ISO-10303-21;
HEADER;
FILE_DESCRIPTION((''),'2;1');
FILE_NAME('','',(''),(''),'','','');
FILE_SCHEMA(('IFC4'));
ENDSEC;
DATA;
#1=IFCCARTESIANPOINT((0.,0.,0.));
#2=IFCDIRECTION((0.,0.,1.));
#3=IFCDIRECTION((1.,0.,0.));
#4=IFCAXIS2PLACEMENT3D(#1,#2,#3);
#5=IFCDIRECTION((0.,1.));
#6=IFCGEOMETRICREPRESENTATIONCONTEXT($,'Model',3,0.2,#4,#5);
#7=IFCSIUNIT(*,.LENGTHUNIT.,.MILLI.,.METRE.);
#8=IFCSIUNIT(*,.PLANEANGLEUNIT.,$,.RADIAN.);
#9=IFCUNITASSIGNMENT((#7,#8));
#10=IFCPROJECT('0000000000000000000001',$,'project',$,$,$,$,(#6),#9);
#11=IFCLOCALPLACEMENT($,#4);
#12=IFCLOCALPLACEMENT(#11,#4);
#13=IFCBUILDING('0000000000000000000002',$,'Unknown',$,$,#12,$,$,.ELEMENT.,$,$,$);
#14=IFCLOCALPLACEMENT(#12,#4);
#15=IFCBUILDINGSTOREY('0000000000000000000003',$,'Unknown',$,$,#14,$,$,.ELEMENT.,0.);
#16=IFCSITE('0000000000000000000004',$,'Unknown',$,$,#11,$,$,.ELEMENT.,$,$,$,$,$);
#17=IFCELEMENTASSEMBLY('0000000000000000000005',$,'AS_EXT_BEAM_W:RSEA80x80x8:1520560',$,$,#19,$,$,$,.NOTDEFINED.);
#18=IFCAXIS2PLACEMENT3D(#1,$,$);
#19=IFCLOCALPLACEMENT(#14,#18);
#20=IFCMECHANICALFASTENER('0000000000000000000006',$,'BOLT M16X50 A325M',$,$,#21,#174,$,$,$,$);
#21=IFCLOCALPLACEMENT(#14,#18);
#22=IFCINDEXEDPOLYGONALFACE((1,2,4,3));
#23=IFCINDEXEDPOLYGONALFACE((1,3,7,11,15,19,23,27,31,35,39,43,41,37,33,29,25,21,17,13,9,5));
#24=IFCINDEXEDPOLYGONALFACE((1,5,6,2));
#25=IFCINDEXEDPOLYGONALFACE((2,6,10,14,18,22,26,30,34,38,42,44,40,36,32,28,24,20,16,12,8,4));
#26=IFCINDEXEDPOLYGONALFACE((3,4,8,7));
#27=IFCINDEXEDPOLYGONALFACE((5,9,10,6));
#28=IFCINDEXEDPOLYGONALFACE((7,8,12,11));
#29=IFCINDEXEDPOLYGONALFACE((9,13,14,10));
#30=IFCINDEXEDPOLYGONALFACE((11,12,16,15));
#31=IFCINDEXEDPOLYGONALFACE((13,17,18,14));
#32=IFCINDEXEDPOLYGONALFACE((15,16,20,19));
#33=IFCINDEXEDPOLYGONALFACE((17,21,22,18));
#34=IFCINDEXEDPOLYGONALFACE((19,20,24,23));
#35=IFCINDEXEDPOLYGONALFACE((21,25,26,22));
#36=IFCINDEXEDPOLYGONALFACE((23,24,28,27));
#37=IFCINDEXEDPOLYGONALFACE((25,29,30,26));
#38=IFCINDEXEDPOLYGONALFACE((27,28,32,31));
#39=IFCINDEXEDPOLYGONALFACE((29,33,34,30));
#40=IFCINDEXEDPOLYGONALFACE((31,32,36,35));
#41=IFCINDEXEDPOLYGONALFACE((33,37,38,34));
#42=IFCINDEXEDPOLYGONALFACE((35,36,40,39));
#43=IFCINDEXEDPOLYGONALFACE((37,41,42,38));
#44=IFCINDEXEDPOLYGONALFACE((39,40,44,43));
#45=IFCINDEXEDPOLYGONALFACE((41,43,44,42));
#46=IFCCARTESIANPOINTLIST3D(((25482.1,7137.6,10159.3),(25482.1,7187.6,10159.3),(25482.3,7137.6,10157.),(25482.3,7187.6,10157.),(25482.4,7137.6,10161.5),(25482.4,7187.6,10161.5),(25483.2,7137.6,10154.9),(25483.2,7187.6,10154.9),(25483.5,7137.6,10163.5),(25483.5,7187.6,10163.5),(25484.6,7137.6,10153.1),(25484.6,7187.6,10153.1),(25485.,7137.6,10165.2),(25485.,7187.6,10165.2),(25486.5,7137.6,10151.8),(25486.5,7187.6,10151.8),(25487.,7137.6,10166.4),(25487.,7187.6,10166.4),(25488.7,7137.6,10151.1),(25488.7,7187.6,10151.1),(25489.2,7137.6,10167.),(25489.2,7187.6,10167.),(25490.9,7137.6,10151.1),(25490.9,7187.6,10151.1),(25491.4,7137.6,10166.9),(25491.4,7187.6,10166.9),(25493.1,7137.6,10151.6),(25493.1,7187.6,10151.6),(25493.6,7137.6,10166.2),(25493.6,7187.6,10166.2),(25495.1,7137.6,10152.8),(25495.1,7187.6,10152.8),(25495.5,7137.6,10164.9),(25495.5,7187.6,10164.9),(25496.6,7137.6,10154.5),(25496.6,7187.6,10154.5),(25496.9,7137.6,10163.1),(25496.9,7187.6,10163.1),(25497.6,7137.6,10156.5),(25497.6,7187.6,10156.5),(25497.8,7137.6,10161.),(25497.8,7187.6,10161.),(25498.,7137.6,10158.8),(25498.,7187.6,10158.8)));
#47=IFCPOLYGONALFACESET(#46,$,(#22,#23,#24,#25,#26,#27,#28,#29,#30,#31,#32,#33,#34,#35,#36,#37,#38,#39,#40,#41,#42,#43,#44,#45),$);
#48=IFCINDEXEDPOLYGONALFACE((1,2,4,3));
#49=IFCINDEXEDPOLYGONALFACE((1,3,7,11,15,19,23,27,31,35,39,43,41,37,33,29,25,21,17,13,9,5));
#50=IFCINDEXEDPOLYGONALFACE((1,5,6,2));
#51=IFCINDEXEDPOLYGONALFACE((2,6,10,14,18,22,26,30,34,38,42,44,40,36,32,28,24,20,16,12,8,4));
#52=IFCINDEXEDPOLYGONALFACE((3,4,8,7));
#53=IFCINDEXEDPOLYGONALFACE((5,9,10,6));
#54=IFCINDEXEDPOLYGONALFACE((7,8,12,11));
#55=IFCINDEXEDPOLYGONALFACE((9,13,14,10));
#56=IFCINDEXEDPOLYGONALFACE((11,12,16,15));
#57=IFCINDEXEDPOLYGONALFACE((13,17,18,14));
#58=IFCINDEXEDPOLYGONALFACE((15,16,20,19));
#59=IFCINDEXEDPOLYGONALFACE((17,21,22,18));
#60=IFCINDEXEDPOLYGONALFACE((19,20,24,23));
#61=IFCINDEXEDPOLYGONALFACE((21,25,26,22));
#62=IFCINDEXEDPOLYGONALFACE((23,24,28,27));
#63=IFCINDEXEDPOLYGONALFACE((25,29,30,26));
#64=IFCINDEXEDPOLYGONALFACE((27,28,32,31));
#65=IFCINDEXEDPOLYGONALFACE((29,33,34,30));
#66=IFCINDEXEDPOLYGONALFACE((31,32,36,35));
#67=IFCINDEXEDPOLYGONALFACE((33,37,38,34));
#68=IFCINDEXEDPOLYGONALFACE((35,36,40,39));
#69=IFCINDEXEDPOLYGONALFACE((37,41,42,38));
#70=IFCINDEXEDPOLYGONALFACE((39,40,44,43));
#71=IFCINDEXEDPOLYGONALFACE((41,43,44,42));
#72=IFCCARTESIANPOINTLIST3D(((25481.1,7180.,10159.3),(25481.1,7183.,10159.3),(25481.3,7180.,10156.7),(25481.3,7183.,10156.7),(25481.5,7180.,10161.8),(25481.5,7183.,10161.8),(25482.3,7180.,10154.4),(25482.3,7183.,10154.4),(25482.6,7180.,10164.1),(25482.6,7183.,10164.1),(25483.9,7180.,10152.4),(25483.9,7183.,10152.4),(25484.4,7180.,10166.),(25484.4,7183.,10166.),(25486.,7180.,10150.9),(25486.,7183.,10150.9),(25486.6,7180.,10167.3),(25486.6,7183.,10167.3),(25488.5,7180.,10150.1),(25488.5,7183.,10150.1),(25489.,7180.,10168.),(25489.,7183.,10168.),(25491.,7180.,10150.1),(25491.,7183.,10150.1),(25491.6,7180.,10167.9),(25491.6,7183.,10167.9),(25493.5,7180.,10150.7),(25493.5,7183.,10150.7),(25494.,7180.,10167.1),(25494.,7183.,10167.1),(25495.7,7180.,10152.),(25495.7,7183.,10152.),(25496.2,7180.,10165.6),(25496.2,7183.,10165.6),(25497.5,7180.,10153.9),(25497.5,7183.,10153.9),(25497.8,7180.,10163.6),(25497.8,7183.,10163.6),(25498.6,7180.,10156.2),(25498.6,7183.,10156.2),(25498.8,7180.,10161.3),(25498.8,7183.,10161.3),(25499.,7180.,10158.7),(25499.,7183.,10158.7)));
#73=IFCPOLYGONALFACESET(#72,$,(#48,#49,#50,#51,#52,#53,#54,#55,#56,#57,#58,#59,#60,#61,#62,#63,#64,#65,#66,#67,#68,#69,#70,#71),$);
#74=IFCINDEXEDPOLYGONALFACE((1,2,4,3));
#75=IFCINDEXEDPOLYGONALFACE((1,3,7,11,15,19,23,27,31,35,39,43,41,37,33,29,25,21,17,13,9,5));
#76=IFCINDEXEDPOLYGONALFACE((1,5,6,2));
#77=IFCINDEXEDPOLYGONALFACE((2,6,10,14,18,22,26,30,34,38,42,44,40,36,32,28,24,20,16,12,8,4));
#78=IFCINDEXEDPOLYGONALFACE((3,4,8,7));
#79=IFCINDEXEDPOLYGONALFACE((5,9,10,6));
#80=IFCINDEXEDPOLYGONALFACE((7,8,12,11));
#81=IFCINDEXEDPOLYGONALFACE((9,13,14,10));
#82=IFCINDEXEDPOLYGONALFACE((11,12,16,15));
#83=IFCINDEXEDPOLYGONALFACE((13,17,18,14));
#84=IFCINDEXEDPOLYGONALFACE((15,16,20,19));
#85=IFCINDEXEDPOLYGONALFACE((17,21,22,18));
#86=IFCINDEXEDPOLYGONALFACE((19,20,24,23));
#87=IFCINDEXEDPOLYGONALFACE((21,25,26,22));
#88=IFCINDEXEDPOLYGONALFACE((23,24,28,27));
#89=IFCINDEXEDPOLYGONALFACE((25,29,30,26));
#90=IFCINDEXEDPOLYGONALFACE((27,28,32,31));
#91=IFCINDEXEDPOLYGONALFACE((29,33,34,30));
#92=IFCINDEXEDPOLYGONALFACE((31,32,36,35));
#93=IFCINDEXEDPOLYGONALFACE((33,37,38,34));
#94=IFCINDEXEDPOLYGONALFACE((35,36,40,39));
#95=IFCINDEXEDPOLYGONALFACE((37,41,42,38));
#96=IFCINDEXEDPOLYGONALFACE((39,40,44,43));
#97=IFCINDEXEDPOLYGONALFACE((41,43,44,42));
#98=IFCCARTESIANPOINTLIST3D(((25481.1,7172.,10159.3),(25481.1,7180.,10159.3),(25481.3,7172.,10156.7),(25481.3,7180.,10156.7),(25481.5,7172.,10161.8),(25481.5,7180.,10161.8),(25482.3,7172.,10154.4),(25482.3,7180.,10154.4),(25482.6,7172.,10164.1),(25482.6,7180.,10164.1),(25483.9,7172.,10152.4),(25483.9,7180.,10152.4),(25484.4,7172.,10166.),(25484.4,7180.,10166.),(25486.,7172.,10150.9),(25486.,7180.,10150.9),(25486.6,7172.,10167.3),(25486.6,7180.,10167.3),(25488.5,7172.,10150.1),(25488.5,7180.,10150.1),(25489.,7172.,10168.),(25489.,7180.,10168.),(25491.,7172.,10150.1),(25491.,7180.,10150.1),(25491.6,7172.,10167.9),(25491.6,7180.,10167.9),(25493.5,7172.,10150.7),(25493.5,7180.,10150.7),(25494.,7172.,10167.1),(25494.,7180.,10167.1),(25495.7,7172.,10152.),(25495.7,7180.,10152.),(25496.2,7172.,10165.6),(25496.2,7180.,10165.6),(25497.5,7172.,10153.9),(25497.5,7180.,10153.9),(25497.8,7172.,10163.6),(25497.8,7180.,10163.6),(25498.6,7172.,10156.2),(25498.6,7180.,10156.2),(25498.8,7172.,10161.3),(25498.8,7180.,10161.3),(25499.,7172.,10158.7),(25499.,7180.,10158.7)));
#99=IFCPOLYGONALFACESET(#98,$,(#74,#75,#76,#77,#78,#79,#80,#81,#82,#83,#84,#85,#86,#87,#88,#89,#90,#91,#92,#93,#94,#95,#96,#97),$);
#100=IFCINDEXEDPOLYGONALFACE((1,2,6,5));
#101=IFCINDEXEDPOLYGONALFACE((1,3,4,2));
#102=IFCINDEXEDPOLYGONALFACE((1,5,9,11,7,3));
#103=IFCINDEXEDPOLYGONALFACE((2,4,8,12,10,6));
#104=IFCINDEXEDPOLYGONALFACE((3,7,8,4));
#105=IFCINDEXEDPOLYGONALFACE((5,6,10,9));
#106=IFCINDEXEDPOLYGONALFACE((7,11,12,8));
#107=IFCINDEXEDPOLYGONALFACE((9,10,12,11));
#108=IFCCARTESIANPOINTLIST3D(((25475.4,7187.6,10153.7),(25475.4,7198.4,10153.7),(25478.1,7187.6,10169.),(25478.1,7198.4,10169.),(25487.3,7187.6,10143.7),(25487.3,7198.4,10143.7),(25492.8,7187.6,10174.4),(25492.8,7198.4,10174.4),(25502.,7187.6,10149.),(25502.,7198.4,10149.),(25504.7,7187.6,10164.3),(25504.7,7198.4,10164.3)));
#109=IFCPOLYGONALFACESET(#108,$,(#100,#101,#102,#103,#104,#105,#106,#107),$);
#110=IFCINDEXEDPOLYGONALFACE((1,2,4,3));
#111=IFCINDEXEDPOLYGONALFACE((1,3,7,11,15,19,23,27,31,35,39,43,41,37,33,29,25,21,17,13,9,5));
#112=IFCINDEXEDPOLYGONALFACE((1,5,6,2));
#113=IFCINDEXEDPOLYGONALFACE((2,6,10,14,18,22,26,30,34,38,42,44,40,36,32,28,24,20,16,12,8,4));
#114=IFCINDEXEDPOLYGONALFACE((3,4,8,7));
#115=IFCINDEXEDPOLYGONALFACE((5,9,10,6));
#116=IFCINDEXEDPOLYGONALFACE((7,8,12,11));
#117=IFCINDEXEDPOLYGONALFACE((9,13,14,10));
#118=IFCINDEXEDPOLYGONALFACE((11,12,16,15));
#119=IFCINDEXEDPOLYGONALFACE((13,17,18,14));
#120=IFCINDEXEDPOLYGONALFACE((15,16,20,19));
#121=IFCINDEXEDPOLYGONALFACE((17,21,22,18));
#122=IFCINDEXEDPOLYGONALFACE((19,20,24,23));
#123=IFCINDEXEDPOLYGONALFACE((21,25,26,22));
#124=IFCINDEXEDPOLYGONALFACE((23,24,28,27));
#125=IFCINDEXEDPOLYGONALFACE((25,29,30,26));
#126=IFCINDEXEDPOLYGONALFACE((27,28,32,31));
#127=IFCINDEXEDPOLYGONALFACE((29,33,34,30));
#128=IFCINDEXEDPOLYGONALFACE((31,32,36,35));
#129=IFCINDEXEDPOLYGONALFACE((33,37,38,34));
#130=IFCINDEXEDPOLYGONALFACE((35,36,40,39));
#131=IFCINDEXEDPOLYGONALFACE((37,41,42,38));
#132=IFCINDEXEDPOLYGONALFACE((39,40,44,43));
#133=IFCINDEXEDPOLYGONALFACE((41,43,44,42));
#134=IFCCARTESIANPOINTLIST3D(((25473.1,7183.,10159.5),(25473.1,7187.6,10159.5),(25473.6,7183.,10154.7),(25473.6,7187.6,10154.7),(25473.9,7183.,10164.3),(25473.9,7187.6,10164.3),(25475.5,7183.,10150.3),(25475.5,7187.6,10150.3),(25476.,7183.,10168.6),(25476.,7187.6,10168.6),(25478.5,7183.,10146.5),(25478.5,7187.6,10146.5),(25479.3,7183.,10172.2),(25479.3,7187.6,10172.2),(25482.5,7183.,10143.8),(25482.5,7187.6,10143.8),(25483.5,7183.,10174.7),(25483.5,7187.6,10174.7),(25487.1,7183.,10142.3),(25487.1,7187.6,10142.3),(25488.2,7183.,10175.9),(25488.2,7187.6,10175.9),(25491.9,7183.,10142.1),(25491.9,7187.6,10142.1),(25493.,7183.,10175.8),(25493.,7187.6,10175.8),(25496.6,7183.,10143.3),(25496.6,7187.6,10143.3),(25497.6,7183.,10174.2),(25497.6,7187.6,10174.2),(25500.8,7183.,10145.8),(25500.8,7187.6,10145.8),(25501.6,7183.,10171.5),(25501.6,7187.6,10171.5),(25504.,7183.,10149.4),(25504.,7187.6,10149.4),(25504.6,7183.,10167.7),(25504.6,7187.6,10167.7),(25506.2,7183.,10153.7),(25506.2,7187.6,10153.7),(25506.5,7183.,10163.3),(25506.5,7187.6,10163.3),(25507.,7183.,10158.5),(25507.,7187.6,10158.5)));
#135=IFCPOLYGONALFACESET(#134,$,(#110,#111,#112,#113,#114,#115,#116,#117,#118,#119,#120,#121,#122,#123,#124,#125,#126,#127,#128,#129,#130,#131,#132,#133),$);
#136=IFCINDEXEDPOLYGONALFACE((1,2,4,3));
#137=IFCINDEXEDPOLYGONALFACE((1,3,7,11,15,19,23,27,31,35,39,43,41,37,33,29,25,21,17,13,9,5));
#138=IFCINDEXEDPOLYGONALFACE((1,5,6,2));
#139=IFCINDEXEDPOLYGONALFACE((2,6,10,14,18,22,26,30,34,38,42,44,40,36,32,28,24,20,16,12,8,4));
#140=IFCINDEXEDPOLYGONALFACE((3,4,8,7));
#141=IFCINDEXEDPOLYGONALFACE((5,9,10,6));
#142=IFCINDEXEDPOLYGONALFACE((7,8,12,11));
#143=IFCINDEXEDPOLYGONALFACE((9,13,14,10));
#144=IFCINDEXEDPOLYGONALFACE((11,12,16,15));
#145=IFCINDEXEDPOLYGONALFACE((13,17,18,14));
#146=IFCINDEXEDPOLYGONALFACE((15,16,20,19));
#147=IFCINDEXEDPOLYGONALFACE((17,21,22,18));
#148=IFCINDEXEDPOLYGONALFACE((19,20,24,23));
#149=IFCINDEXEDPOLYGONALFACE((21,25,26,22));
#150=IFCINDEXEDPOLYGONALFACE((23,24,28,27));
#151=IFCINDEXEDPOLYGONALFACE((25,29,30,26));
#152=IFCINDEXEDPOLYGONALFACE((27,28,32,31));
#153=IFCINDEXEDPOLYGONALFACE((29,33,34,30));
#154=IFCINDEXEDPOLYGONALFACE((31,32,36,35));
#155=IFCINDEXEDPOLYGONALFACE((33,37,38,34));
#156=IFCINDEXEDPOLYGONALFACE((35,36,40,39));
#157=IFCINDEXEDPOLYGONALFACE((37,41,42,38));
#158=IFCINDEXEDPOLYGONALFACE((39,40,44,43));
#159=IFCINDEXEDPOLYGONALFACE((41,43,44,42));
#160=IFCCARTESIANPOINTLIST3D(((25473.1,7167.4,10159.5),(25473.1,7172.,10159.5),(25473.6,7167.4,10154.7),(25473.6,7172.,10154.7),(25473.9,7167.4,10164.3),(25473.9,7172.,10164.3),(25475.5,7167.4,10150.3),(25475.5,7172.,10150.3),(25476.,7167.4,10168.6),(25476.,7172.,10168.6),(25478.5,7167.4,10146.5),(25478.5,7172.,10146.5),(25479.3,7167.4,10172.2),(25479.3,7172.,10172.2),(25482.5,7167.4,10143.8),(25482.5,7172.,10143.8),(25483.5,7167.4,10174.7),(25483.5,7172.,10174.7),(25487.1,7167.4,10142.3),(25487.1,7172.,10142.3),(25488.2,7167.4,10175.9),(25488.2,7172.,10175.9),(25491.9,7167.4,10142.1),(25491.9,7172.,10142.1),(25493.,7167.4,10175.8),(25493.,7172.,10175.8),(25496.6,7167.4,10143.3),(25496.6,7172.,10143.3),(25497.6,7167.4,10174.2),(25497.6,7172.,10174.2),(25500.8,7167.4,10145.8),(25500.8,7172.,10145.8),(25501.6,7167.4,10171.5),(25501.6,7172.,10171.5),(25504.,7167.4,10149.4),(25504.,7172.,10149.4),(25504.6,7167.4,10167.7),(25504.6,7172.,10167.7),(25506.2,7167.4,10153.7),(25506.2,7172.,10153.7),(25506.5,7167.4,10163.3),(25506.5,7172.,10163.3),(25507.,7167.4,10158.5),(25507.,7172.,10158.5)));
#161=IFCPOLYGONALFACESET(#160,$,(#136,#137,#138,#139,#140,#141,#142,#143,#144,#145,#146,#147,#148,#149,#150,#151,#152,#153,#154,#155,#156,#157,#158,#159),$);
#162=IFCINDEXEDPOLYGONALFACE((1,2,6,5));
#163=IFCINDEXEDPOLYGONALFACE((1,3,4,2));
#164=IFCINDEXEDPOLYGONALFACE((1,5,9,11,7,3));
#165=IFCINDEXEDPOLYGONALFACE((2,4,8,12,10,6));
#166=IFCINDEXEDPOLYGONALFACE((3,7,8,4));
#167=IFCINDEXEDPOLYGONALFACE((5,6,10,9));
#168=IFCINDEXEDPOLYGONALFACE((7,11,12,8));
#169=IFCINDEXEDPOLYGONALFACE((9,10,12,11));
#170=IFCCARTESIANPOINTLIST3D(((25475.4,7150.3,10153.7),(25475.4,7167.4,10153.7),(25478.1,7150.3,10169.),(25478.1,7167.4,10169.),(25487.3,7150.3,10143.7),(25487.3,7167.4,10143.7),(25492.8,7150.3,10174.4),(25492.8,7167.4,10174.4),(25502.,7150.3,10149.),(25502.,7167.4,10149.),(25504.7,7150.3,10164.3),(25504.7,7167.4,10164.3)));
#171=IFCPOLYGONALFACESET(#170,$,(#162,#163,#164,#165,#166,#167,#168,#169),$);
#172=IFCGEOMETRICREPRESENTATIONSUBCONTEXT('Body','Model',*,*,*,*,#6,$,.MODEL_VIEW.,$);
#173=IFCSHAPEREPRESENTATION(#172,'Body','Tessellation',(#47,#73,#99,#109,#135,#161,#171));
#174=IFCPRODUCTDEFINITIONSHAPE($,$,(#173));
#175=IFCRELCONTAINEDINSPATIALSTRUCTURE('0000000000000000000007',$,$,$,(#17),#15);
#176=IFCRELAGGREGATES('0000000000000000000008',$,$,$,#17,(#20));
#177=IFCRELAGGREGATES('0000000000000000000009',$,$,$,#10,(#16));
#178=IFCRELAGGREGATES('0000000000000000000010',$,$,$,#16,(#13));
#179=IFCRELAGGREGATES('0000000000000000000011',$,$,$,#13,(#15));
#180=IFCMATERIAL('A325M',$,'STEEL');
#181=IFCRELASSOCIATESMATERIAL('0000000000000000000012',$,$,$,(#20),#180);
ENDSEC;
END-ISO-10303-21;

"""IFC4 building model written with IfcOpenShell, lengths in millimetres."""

from ifc_helpers import new_model, si_unit, direction, frame, origin_with_axes, place, context, subcontext, project, spatial, line, arc, indexed_curve, outline, extrude, source, transform, mapped, material, element, aggregate, save


model = new_model("IFC4")

# Units and contexts
model_context = context("Model", 3, precision=0.2, world=origin_with_axes(), true_north=direction((0.0, 1.0)))
body_context = subcontext(model_context, "Body", "Model", "MODEL_VIEW")
ifc_project = project(units=[si_unit("LENGTHUNIT", "METRE", prefix="MILLI"), si_unit("PLANEANGLEUNIT", "RADIAN")], contexts=[model_context])

# Site, building, storey
site_placement = place(None, origin_with_axes())
site = spatial("IfcSite", under=ifc_project, at=site_placement, Name="Unknown", CompositionType="ELEMENT")
building_placement = place(site_placement, origin_with_axes())
building = spatial("IfcBuilding", under=site, at=building_placement, Name="Unknown", CompositionType="ELEMENT")
storey_placement = place(building_placement, origin_with_axes())
storey = spatial("IfcBuildingStorey", under=building, at=storey_placement, Name="Unknown", CompositionType="ELEMENT", Elevation=0.0)

# Element assembly
assembly_1_placement = place(storey_placement, frame((25427.6, 7140.0, 10164.9), z_axis=(0.0, -1.0, 0.0), x_axis=(0.984808, 0.0, -0.173648)))
assembly_1 = element("IfcElementAssembly", 1, at=assembly_1_placement, inside=storey, Name="AS_EXT_BEAM_W:RSEA80x80x8:1520560", PredefinedType="NOTDEFINED")

# Mechanical fastener
ifc_material_1 = material(Name="A325M", Category="STEEL")
shared_shape_1 = source(origin_with_axes(), body_context, "Body", "SweptSolid", [
    extrude(outline(indexed_curve([(8.0, 0.0), (0.0, 8.0), (-8.0, 0.0), (0.0, -8.0)], segments=[arc(1, 2, 3), arc(3, 4, 1)])), frame((0.0, 0.0, 15.6), z_axis=(0.0, 0.0, -1.0), x_axis=(0.0, 1.0, 0.0)), (0.0, 0.0, 1.0), 50.0),
    extrude(outline(indexed_curve([(9.0, 0.0), (0.0, 9.0), (-9.0, 0.0), (0.0, -9.0)], segments=[arc(1, 2, 3), arc(3, 4, 1)])), frame((0.0, 0.0, 11.0), z_axis=(0.0, 0.0, -1.0), x_axis=(0.0, 1.0, 0.0)), (0.0, 0.0, 1.0), 3.0),
    extrude(outline(indexed_curve([(9.0, 0.0), (0.0, 9.0), (-9.0, 0.0), (0.0, -9.0)], segments=[arc(1, 2, 3), arc(3, 4, 1)])), frame((0.0, 0.0, 8.0), z_axis=(0.0, 0.0, -1.0), x_axis=(0.0, 1.0, 0.0)), (0.0, 0.0, 1.0), 8.0),
    extrude(outline(indexed_curve([(15.6, 0.0), (7.8, 13.5), (-7.8, 13.5), (-15.6, 0.0), (-7.8, -13.5), (7.8, -13.5)], segments=[line(1, 2, 3, 4, 5, 6, 1)])), frame((0.0, 0.0, 26.4), z_axis=(0.0, 0.0, -1.0), x_axis=(0.0, 1.0, 0.0)), (0.0, 0.0, 1.0), 10.8),
    extrude(outline(indexed_curve([(17.0, 0.0), (0.0, 17.0), (-17.0, 0.0), (0.0, -17.0)], segments=[arc(1, 2, 3), arc(3, 4, 1)])), frame((0.0, 0.0, 15.6), z_axis=(0.0, 0.0, -1.0), x_axis=(0.0, 1.0, 0.0)), (0.0, 0.0, 1.0), 4.6),
    extrude(outline(indexed_curve([(17.0, 0.0), (0.0, 17.0), (-17.0, 0.0), (0.0, -17.0)], segments=[arc(1, 2, 3), arc(3, 4, 1)])), frame((0.0, 0.0, 0.0), z_axis=(0.0, 0.0, -1.0), x_axis=(0.0, 1.0, 0.0)), (0.0, 0.0, 1.0), 4.6),
    extrude(outline(indexed_curve([(15.6, 0.0), (7.8, 13.5), (-7.8, 13.5), (-15.6, 0.0), (-7.8, -13.5), (7.8, -13.5)], segments=[line(1, 2, 3, 4, 5, 6, 1)])), frame((0.0, 0.0, -4.6), z_axis=(0.0, 0.0, -1.0), x_axis=(0.0, 1.0, 0.0)), (0.0, 0.0, 1.0), 17.1),
])
mechanical_fastener_1_placement = place(assembly_1_placement, frame((62.5, 5.0, -32.0), z_axis=(0.0, 0.0, -1.0), x_axis=(1.0, 0.0, 0.0)))
mechanical_fastener_1 = element("IfcMechanicalFastener", 2, at=mechanical_fastener_1_placement, material=ifc_material_1, Name="BOLT M16X50 A325M", context=body_context, shape_type="MappedRepresentation", body=[
    mapped(shared_shape_1, transform((0.0, 0.0, 0.0))),
])
aggregate(assembly_1, [mechanical_fastener_1])

save(model, "model.ifc")
